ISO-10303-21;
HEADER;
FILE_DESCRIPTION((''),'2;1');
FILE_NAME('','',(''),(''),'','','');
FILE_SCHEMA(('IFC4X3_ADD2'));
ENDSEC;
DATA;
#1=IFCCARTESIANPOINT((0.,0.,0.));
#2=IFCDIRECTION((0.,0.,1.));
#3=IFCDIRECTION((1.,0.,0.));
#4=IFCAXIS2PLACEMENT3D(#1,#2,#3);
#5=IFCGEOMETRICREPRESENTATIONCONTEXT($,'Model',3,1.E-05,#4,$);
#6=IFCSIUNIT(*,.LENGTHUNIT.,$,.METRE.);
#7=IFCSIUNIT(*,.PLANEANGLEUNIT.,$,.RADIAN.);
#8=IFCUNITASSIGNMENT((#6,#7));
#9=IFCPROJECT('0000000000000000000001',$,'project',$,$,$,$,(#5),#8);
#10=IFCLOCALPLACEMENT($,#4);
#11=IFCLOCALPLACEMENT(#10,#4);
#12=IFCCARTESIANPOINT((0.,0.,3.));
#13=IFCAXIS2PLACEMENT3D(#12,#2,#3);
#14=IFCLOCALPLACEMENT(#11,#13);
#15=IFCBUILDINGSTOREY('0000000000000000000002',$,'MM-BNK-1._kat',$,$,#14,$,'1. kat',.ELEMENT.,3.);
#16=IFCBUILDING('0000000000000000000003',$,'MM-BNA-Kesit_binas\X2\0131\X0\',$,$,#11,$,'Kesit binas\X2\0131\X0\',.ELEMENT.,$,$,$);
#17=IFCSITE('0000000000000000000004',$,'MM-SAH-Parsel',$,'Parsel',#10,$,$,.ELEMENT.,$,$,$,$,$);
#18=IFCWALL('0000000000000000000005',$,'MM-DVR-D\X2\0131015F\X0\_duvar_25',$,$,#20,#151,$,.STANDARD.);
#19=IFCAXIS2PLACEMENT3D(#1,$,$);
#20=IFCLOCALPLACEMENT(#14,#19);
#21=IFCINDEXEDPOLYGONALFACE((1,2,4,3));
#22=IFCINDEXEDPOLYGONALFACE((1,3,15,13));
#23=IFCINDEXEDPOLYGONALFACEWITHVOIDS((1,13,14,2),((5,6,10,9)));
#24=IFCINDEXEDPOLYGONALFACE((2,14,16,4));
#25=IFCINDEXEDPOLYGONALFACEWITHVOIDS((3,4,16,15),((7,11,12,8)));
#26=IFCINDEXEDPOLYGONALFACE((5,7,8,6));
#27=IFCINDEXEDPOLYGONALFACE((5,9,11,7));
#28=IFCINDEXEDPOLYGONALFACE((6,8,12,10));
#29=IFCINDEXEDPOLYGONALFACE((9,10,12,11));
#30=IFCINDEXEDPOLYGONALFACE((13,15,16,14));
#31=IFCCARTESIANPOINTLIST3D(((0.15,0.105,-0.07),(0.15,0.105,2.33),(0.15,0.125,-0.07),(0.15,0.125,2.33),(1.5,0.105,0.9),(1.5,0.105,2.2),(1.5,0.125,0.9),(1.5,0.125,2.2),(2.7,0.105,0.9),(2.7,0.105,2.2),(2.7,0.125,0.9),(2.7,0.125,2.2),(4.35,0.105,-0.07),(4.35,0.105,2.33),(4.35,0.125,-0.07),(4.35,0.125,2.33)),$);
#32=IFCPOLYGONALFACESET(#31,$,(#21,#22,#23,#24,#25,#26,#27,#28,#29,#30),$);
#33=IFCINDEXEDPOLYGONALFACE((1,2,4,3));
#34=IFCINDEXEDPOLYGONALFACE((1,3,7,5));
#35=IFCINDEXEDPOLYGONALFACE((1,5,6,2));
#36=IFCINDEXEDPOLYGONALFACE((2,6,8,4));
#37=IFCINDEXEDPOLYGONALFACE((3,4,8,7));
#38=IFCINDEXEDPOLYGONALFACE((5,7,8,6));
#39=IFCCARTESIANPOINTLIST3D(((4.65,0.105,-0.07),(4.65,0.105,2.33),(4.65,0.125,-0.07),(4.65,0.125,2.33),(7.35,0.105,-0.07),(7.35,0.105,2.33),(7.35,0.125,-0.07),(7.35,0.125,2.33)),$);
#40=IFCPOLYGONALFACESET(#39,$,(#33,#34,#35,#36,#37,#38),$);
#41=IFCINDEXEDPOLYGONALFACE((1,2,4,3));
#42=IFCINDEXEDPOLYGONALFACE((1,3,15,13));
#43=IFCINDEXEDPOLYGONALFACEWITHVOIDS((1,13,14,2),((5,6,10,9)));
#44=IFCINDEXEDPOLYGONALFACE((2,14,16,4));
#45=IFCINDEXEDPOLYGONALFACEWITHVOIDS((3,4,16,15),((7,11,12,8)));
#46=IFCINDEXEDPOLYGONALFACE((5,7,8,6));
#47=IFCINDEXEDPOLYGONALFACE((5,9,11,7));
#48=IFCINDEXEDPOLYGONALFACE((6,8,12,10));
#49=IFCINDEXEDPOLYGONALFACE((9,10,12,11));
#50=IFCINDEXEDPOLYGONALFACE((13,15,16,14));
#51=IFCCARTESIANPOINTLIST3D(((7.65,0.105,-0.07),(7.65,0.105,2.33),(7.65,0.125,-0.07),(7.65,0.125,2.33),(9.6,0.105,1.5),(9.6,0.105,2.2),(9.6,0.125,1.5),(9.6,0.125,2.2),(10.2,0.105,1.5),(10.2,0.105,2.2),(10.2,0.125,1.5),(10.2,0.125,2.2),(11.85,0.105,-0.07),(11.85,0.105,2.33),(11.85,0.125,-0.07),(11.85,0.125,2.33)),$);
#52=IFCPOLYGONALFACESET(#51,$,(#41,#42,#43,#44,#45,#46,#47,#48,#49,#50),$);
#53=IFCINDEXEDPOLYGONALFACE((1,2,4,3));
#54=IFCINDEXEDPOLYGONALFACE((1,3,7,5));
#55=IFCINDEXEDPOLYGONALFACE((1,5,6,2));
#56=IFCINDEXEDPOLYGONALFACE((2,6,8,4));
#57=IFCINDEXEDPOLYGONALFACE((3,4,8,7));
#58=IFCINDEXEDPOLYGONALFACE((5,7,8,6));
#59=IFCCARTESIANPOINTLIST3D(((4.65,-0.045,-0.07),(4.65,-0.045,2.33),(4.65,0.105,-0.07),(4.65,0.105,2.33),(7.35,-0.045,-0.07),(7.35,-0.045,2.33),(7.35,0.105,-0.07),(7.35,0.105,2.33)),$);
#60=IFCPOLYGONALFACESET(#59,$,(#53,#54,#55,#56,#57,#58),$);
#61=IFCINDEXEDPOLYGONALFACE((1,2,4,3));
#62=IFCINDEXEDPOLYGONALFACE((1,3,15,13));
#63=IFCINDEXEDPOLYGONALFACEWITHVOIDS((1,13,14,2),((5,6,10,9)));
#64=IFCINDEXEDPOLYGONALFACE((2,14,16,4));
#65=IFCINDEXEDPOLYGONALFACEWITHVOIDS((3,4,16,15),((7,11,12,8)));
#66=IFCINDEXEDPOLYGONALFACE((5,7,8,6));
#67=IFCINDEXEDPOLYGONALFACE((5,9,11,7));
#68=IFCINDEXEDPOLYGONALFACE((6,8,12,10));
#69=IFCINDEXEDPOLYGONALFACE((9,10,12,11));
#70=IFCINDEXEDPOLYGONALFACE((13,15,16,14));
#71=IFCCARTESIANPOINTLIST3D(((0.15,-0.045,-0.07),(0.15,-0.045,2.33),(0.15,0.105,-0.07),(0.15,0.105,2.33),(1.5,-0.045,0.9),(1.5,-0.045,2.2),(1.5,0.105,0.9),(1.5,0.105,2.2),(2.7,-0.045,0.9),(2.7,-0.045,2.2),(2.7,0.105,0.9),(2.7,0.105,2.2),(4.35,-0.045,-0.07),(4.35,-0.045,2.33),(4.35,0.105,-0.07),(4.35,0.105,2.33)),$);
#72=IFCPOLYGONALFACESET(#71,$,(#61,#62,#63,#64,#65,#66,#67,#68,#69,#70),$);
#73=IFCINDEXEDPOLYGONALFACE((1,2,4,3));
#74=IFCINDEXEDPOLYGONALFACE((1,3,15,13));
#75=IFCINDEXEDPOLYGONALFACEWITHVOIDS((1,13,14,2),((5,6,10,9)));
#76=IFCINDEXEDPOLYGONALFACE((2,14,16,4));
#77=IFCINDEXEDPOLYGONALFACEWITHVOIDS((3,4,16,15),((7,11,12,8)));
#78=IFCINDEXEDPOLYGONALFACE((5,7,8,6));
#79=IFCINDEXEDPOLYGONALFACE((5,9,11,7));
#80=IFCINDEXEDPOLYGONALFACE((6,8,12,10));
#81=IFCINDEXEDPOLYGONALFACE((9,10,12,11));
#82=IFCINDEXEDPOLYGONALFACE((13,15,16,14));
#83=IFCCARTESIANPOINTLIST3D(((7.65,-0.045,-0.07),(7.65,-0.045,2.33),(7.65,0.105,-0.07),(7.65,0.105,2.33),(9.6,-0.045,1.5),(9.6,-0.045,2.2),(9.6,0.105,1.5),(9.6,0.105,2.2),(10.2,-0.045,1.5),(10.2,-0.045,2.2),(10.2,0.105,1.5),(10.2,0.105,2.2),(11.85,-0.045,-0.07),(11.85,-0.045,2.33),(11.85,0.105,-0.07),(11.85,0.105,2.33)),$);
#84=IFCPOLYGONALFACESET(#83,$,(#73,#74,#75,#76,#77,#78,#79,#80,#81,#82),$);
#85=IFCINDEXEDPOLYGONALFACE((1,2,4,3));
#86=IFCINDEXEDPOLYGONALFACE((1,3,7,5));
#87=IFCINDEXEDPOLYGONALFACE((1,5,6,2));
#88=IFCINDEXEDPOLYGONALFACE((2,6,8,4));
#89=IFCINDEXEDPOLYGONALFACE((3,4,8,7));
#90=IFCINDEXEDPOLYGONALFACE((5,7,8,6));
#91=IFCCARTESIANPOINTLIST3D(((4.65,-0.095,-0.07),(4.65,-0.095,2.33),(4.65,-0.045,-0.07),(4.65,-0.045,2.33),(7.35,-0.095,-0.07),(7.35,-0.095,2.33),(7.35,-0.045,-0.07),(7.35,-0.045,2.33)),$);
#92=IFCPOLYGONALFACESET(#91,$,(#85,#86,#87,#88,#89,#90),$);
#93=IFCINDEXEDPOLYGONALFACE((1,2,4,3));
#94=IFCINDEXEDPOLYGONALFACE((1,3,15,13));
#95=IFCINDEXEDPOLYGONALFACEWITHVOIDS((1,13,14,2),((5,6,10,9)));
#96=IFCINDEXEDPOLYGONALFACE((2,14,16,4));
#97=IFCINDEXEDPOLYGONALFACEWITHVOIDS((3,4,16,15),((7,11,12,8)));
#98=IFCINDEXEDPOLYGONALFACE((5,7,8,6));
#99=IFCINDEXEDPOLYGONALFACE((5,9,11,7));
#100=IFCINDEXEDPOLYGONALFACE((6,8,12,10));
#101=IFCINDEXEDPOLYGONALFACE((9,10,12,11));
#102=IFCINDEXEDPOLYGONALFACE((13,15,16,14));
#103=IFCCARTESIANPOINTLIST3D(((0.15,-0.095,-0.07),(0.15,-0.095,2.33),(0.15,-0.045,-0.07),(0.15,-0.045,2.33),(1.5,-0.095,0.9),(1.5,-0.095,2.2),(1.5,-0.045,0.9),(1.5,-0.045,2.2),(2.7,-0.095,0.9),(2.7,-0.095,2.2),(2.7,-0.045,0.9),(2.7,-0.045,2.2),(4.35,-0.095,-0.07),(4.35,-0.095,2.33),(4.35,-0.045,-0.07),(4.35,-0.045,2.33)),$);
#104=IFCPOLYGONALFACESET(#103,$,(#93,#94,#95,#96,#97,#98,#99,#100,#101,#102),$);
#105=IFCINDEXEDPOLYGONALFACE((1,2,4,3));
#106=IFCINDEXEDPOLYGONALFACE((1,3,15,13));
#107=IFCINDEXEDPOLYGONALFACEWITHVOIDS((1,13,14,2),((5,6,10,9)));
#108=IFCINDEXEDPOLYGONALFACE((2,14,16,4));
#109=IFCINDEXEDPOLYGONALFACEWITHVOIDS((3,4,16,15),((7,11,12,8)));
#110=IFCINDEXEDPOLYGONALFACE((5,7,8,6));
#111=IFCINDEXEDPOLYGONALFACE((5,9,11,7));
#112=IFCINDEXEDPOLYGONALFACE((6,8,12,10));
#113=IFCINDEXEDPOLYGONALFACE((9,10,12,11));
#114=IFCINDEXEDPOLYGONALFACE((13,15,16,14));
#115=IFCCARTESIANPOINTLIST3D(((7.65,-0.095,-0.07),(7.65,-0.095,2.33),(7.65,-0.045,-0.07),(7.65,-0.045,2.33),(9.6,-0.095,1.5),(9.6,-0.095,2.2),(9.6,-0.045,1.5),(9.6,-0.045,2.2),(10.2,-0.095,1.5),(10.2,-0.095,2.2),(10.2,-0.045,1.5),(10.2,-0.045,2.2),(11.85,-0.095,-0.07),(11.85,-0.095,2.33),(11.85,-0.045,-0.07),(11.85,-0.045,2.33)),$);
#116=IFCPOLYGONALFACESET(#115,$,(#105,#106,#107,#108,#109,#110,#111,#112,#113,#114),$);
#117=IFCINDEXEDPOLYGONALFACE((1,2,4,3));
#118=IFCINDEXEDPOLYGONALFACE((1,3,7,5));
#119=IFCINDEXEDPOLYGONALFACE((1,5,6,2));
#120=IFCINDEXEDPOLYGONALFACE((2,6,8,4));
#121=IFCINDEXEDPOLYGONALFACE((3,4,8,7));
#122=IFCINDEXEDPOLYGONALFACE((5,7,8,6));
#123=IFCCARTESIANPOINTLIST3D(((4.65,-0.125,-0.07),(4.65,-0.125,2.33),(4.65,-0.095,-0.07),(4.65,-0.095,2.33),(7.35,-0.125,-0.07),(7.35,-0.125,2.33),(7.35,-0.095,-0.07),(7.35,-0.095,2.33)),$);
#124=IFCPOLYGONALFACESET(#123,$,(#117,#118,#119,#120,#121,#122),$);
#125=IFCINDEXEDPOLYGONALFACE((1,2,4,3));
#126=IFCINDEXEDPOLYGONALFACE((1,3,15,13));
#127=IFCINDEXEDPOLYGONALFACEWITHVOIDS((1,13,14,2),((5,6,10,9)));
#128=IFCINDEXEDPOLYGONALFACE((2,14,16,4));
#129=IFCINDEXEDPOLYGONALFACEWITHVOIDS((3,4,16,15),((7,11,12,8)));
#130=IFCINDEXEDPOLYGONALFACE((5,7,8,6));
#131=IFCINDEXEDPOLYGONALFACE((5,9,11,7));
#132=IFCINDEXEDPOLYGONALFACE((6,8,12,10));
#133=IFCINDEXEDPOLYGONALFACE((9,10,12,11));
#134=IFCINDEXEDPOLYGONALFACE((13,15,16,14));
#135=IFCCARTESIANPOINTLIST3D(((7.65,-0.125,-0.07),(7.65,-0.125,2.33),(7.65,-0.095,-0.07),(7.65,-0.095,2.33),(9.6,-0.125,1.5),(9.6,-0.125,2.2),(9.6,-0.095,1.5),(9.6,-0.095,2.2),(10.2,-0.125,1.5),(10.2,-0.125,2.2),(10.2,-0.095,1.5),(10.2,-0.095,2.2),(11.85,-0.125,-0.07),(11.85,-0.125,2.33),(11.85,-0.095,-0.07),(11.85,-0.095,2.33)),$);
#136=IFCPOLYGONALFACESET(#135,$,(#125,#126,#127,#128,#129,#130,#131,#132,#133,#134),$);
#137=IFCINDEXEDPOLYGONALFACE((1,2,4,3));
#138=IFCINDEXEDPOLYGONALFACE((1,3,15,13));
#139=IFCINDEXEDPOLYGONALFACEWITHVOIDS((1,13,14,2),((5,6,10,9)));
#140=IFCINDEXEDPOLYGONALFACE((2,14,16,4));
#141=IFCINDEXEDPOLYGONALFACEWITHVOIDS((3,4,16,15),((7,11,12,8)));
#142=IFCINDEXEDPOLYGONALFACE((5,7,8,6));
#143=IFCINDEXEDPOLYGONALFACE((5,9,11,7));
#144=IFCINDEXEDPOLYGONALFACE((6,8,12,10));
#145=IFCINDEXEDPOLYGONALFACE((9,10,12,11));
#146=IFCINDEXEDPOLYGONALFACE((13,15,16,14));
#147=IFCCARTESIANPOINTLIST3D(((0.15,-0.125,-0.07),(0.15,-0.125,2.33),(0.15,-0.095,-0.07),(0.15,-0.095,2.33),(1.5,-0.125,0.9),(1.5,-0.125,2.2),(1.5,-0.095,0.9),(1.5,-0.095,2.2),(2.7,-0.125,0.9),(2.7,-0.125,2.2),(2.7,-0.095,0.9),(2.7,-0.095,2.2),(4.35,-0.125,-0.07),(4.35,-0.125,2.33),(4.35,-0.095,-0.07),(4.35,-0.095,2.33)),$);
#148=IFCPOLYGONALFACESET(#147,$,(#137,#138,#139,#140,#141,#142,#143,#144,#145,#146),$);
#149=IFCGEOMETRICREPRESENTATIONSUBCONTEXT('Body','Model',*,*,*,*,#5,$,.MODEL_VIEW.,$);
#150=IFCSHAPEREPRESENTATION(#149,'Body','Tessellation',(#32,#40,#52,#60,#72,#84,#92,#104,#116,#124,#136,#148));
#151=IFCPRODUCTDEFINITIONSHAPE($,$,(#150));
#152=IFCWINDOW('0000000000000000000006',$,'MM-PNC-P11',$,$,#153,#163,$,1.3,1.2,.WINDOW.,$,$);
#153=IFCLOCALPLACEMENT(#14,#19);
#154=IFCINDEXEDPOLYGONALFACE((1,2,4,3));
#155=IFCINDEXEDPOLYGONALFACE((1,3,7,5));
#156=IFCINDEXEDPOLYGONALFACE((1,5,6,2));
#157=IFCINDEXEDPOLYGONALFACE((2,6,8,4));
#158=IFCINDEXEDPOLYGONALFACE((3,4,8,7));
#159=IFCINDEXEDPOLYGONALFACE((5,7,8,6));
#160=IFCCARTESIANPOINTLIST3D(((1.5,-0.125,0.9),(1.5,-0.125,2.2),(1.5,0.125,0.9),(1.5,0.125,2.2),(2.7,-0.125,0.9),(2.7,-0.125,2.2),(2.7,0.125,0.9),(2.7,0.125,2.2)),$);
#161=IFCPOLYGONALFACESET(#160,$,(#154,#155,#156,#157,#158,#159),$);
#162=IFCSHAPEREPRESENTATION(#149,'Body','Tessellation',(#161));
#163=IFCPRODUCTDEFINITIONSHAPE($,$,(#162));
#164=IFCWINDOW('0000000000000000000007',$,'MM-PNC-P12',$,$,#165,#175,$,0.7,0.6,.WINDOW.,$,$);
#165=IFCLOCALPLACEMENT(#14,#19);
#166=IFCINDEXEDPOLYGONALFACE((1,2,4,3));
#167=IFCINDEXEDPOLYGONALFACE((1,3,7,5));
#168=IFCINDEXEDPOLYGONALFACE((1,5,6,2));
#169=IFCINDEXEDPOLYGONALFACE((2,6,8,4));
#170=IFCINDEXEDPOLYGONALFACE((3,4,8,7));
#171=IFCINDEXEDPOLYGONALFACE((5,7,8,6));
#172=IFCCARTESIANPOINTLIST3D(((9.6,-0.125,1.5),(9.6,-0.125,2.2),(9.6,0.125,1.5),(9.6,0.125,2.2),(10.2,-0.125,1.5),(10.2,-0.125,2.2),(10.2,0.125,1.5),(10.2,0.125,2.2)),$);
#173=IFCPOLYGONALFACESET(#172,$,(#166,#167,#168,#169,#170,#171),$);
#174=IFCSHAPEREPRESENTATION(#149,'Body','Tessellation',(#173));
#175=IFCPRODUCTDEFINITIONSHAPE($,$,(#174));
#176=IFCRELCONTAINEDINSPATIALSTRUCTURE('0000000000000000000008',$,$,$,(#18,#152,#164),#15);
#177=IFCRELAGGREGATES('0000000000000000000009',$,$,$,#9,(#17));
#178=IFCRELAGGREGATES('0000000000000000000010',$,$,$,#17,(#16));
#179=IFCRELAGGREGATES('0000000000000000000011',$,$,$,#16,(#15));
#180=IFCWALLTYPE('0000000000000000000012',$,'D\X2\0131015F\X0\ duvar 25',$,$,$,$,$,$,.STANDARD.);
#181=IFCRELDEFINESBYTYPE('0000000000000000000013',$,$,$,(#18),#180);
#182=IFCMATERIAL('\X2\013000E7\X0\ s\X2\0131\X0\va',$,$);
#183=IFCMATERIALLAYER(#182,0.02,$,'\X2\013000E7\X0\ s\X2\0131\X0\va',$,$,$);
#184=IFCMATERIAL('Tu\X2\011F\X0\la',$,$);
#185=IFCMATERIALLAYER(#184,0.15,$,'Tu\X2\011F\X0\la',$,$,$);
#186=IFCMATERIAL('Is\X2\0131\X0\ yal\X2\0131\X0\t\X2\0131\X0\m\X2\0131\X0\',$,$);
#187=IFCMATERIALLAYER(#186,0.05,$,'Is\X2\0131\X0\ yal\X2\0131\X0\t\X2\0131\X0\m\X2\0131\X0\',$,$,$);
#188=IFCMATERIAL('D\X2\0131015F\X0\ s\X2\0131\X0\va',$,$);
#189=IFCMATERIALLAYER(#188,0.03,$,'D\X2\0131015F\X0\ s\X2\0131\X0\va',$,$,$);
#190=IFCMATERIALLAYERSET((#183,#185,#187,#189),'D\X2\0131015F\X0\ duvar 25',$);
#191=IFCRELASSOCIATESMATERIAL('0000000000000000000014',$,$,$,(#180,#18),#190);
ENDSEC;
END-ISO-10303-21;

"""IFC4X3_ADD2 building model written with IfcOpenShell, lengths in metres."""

from ifc_helpers import new_model, si_unit, frame, origin_with_axes, place, context, subcontext, project, spatial, polyline, outline, extrude, material, layer, layer_set, type_object, element, fill, save


model = new_model("IFC4X3_ADD2")

# Units and contexts
model_context = context("Model", 3, precision=1e-05, world=origin_with_axes())
body_context = subcontext(model_context, "Body", "Model", "MODEL_VIEW")
ifc_project = project(units=[si_unit("LENGTHUNIT", "METRE"), si_unit("PLANEANGLEUNIT", "RADIAN")], contexts=[model_context])

# Site, building, storey
site_placement = place(None, origin_with_axes())
site = spatial("IfcSite", under=ifc_project, at=site_placement, Name="MM-SAH-Parsel", ObjectType="Parsel", CompositionType="ELEMENT")
building_placement = place(site_placement, origin_with_axes())
building = spatial("IfcBuilding", under=site, at=building_placement, Name="MM-BNA-Kesit_binası", LongName="Kesit binası", CompositionType="ELEMENT")
storey_placement = place(building_placement, frame((0.0, 0.0, 3.0), z_axis=(0.0, 0.0, 1.0), x_axis=(1.0, 0.0, 0.0)))
storey = spatial("IfcBuildingStorey", under=building, at=storey_placement, Name="MM-BNK-1._kat", LongName="1. kat", CompositionType="ELEMENT", Elevation=3.0)

# Wall, openings, windows
ifc_material_1 = material(Name="İç sıva")
ifc_layer_1 = layer(ifc_material_1, 0.02, Name="İç sıva")
ifc_material_2 = material(Name="Tuğla")
ifc_layer_2 = layer(ifc_material_2, 0.15, Name="Tuğla")
ifc_material_3 = material(Name="Isı yalıtımı")
ifc_layer_3 = layer(ifc_material_3, 0.05, Name="Isı yalıtımı")
ifc_material_4 = material(Name="Dış sıva")
ifc_layer_4 = layer(ifc_material_4, 0.03, Name="Dış sıva")
ifc_layer_set_1 = layer_set([ifc_layer_1, ifc_layer_2, ifc_layer_3, ifc_layer_4], Name="Dış duvar 25")
wall_type_1 = type_object("IfcWallType", Name="Dış duvar 25", PredefinedType="STANDARD", material=ifc_layer_set_1)
wall_1_placement = place(storey_placement, origin_with_axes())
wall_1 = element("IfcWall", 1, at=wall_1_placement, inside=storey, type_object=wall_type_1, material=ifc_layer_set_1, Name="MM-DVR-Dış_duvar_25", PredefinedType="STANDARD", context=body_context, shape_type="SweptSolid", body=[
    extrude(outline(polyline([(0.15, 0.105), (4.35, 0.105), (4.35, 0.125), (0.15, 0.125), (0.15, 0.105)])), frame((0.0, 0.0, -0.07)), (0.0, 0.0, 1.0), 2.4),
    extrude(outline(polyline([(4.65, 0.105), (7.35, 0.105), (7.35, 0.125), (4.65, 0.125), (4.65, 0.105)])), frame((0.0, 0.0, -0.07)), (0.0, 0.0, 1.0), 2.4),
    extrude(outline(polyline([(7.65, 0.105), (11.85, 0.105), (11.85, 0.125), (7.65, 0.125), (7.65, 0.105)])), frame((0.0, 0.0, -0.07)), (0.0, 0.0, 1.0), 2.4),
    extrude(outline(polyline([(4.65, -0.045), (7.35, -0.045), (7.35, 0.105), (4.65, 0.105), (4.65, -0.045)])), frame((0.0, 0.0, -0.07)), (0.0, 0.0, 1.0), 2.4),
    extrude(outline(polyline([(0.15, -0.045), (4.35, -0.045), (4.35, 0.105), (0.15, 0.105), (0.15, -0.045)])), frame((0.0, 0.0, -0.07)), (0.0, 0.0, 1.0), 2.4),
    extrude(outline(polyline([(7.65, -0.045), (11.85, -0.045), (11.85, 0.105), (7.65, 0.105), (7.65, -0.045)])), frame((0.0, 0.0, -0.07)), (0.0, 0.0, 1.0), 2.4),
    extrude(outline(polyline([(4.65, -0.095), (7.35, -0.095), (7.35, -0.045), (4.65, -0.045), (4.65, -0.095)])), frame((0.0, 0.0, -0.07)), (0.0, 0.0, 1.0), 2.4),
    extrude(outline(polyline([(0.15, -0.095), (4.35, -0.095), (4.35, -0.045), (0.15, -0.045), (0.15, -0.095)])), frame((0.0, 0.0, -0.07)), (0.0, 0.0, 1.0), 2.4),
    extrude(outline(polyline([(7.65, -0.095), (11.85, -0.095), (11.85, -0.045), (7.65, -0.045), (7.65, -0.095)])), frame((0.0, 0.0, -0.07)), (0.0, 0.0, 1.0), 2.4),
    extrude(outline(polyline([(4.65, -0.125), (7.35, -0.125), (7.35, -0.095), (4.65, -0.095), (4.65, -0.125)])), frame((0.0, 0.0, -0.07)), (0.0, 0.0, 1.0), 2.4),
    extrude(outline(polyline([(7.65, -0.125), (11.85, -0.125), (11.85, -0.095), (7.65, -0.095), (7.65, -0.125)])), frame((0.0, 0.0, -0.07)), (0.0, 0.0, 1.0), 2.4),
    extrude(outline(polyline([(0.15, -0.125), (4.35, -0.125), (4.35, -0.095), (0.15, -0.095), (0.15, -0.125)])), frame((0.0, 0.0, -0.07)), (0.0, 0.0, 1.0), 2.4),
])
opening_1_placement = place(storey_placement, origin_with_axes())
opening_1 = element("IfcOpeningElement", 2, at=opening_1_placement, cuts=wall_1, PredefinedType="OPENING", context=body_context, shape_type="SweptSolid", body=[
    extrude(outline(polyline([(1.5, 0.125), (2.7, 0.125), (2.7, -0.125), (1.5, -0.125), (1.5, 0.125)])), frame((0.0, 0.0, 0.9)), (0.0, 0.0, 1.0), 1.3),
])
opening_2_placement = place(storey_placement, origin_with_axes())
opening_2 = element("IfcOpeningElement", 3, at=opening_2_placement, cuts=wall_1, PredefinedType="OPENING", context=body_context, shape_type="SweptSolid", body=[
    extrude(outline(polyline([(9.6, 0.125), (10.2, 0.125), (10.2, -0.125), (9.6, -0.125), (9.6, 0.125)])), frame((0.0, 0.0, 1.5)), (0.0, 0.0, 1.0), 0.7),
])
window_1_placement = place(storey_placement, origin_with_axes())
window_1 = element("IfcWindow", 4, at=window_1_placement, inside=storey, Name="MM-PNC-P11", OverallHeight=1.3, OverallWidth=1.2, PredefinedType="WINDOW", context=body_context, shape_type="SweptSolid", body=[
    extrude(outline(polyline([(1.5, 0.125), (2.7, 0.125), (2.7, -0.125), (1.5, -0.125), (1.5, 0.125)])), frame((0.0, 0.0, 0.9)), (0.0, 0.0, 1.0), 1.3),
])
fill(opening_1, window_1)
window_2_placement = place(storey_placement, origin_with_axes())
window_2 = element("IfcWindow", 5, at=window_2_placement, inside=storey, Name="MM-PNC-P12", OverallHeight=0.7, OverallWidth=0.6, PredefinedType="WINDOW", context=body_context, shape_type="SweptSolid", body=[
    extrude(outline(polyline([(9.6, 0.125), (10.2, 0.125), (10.2, -0.125), (9.6, -0.125), (9.6, 0.125)])), frame((0.0, 0.0, 1.5)), (0.0, 0.0, 1.0), 0.7),
])
fill(opening_2, window_2)

save(model, "model.ifc")
